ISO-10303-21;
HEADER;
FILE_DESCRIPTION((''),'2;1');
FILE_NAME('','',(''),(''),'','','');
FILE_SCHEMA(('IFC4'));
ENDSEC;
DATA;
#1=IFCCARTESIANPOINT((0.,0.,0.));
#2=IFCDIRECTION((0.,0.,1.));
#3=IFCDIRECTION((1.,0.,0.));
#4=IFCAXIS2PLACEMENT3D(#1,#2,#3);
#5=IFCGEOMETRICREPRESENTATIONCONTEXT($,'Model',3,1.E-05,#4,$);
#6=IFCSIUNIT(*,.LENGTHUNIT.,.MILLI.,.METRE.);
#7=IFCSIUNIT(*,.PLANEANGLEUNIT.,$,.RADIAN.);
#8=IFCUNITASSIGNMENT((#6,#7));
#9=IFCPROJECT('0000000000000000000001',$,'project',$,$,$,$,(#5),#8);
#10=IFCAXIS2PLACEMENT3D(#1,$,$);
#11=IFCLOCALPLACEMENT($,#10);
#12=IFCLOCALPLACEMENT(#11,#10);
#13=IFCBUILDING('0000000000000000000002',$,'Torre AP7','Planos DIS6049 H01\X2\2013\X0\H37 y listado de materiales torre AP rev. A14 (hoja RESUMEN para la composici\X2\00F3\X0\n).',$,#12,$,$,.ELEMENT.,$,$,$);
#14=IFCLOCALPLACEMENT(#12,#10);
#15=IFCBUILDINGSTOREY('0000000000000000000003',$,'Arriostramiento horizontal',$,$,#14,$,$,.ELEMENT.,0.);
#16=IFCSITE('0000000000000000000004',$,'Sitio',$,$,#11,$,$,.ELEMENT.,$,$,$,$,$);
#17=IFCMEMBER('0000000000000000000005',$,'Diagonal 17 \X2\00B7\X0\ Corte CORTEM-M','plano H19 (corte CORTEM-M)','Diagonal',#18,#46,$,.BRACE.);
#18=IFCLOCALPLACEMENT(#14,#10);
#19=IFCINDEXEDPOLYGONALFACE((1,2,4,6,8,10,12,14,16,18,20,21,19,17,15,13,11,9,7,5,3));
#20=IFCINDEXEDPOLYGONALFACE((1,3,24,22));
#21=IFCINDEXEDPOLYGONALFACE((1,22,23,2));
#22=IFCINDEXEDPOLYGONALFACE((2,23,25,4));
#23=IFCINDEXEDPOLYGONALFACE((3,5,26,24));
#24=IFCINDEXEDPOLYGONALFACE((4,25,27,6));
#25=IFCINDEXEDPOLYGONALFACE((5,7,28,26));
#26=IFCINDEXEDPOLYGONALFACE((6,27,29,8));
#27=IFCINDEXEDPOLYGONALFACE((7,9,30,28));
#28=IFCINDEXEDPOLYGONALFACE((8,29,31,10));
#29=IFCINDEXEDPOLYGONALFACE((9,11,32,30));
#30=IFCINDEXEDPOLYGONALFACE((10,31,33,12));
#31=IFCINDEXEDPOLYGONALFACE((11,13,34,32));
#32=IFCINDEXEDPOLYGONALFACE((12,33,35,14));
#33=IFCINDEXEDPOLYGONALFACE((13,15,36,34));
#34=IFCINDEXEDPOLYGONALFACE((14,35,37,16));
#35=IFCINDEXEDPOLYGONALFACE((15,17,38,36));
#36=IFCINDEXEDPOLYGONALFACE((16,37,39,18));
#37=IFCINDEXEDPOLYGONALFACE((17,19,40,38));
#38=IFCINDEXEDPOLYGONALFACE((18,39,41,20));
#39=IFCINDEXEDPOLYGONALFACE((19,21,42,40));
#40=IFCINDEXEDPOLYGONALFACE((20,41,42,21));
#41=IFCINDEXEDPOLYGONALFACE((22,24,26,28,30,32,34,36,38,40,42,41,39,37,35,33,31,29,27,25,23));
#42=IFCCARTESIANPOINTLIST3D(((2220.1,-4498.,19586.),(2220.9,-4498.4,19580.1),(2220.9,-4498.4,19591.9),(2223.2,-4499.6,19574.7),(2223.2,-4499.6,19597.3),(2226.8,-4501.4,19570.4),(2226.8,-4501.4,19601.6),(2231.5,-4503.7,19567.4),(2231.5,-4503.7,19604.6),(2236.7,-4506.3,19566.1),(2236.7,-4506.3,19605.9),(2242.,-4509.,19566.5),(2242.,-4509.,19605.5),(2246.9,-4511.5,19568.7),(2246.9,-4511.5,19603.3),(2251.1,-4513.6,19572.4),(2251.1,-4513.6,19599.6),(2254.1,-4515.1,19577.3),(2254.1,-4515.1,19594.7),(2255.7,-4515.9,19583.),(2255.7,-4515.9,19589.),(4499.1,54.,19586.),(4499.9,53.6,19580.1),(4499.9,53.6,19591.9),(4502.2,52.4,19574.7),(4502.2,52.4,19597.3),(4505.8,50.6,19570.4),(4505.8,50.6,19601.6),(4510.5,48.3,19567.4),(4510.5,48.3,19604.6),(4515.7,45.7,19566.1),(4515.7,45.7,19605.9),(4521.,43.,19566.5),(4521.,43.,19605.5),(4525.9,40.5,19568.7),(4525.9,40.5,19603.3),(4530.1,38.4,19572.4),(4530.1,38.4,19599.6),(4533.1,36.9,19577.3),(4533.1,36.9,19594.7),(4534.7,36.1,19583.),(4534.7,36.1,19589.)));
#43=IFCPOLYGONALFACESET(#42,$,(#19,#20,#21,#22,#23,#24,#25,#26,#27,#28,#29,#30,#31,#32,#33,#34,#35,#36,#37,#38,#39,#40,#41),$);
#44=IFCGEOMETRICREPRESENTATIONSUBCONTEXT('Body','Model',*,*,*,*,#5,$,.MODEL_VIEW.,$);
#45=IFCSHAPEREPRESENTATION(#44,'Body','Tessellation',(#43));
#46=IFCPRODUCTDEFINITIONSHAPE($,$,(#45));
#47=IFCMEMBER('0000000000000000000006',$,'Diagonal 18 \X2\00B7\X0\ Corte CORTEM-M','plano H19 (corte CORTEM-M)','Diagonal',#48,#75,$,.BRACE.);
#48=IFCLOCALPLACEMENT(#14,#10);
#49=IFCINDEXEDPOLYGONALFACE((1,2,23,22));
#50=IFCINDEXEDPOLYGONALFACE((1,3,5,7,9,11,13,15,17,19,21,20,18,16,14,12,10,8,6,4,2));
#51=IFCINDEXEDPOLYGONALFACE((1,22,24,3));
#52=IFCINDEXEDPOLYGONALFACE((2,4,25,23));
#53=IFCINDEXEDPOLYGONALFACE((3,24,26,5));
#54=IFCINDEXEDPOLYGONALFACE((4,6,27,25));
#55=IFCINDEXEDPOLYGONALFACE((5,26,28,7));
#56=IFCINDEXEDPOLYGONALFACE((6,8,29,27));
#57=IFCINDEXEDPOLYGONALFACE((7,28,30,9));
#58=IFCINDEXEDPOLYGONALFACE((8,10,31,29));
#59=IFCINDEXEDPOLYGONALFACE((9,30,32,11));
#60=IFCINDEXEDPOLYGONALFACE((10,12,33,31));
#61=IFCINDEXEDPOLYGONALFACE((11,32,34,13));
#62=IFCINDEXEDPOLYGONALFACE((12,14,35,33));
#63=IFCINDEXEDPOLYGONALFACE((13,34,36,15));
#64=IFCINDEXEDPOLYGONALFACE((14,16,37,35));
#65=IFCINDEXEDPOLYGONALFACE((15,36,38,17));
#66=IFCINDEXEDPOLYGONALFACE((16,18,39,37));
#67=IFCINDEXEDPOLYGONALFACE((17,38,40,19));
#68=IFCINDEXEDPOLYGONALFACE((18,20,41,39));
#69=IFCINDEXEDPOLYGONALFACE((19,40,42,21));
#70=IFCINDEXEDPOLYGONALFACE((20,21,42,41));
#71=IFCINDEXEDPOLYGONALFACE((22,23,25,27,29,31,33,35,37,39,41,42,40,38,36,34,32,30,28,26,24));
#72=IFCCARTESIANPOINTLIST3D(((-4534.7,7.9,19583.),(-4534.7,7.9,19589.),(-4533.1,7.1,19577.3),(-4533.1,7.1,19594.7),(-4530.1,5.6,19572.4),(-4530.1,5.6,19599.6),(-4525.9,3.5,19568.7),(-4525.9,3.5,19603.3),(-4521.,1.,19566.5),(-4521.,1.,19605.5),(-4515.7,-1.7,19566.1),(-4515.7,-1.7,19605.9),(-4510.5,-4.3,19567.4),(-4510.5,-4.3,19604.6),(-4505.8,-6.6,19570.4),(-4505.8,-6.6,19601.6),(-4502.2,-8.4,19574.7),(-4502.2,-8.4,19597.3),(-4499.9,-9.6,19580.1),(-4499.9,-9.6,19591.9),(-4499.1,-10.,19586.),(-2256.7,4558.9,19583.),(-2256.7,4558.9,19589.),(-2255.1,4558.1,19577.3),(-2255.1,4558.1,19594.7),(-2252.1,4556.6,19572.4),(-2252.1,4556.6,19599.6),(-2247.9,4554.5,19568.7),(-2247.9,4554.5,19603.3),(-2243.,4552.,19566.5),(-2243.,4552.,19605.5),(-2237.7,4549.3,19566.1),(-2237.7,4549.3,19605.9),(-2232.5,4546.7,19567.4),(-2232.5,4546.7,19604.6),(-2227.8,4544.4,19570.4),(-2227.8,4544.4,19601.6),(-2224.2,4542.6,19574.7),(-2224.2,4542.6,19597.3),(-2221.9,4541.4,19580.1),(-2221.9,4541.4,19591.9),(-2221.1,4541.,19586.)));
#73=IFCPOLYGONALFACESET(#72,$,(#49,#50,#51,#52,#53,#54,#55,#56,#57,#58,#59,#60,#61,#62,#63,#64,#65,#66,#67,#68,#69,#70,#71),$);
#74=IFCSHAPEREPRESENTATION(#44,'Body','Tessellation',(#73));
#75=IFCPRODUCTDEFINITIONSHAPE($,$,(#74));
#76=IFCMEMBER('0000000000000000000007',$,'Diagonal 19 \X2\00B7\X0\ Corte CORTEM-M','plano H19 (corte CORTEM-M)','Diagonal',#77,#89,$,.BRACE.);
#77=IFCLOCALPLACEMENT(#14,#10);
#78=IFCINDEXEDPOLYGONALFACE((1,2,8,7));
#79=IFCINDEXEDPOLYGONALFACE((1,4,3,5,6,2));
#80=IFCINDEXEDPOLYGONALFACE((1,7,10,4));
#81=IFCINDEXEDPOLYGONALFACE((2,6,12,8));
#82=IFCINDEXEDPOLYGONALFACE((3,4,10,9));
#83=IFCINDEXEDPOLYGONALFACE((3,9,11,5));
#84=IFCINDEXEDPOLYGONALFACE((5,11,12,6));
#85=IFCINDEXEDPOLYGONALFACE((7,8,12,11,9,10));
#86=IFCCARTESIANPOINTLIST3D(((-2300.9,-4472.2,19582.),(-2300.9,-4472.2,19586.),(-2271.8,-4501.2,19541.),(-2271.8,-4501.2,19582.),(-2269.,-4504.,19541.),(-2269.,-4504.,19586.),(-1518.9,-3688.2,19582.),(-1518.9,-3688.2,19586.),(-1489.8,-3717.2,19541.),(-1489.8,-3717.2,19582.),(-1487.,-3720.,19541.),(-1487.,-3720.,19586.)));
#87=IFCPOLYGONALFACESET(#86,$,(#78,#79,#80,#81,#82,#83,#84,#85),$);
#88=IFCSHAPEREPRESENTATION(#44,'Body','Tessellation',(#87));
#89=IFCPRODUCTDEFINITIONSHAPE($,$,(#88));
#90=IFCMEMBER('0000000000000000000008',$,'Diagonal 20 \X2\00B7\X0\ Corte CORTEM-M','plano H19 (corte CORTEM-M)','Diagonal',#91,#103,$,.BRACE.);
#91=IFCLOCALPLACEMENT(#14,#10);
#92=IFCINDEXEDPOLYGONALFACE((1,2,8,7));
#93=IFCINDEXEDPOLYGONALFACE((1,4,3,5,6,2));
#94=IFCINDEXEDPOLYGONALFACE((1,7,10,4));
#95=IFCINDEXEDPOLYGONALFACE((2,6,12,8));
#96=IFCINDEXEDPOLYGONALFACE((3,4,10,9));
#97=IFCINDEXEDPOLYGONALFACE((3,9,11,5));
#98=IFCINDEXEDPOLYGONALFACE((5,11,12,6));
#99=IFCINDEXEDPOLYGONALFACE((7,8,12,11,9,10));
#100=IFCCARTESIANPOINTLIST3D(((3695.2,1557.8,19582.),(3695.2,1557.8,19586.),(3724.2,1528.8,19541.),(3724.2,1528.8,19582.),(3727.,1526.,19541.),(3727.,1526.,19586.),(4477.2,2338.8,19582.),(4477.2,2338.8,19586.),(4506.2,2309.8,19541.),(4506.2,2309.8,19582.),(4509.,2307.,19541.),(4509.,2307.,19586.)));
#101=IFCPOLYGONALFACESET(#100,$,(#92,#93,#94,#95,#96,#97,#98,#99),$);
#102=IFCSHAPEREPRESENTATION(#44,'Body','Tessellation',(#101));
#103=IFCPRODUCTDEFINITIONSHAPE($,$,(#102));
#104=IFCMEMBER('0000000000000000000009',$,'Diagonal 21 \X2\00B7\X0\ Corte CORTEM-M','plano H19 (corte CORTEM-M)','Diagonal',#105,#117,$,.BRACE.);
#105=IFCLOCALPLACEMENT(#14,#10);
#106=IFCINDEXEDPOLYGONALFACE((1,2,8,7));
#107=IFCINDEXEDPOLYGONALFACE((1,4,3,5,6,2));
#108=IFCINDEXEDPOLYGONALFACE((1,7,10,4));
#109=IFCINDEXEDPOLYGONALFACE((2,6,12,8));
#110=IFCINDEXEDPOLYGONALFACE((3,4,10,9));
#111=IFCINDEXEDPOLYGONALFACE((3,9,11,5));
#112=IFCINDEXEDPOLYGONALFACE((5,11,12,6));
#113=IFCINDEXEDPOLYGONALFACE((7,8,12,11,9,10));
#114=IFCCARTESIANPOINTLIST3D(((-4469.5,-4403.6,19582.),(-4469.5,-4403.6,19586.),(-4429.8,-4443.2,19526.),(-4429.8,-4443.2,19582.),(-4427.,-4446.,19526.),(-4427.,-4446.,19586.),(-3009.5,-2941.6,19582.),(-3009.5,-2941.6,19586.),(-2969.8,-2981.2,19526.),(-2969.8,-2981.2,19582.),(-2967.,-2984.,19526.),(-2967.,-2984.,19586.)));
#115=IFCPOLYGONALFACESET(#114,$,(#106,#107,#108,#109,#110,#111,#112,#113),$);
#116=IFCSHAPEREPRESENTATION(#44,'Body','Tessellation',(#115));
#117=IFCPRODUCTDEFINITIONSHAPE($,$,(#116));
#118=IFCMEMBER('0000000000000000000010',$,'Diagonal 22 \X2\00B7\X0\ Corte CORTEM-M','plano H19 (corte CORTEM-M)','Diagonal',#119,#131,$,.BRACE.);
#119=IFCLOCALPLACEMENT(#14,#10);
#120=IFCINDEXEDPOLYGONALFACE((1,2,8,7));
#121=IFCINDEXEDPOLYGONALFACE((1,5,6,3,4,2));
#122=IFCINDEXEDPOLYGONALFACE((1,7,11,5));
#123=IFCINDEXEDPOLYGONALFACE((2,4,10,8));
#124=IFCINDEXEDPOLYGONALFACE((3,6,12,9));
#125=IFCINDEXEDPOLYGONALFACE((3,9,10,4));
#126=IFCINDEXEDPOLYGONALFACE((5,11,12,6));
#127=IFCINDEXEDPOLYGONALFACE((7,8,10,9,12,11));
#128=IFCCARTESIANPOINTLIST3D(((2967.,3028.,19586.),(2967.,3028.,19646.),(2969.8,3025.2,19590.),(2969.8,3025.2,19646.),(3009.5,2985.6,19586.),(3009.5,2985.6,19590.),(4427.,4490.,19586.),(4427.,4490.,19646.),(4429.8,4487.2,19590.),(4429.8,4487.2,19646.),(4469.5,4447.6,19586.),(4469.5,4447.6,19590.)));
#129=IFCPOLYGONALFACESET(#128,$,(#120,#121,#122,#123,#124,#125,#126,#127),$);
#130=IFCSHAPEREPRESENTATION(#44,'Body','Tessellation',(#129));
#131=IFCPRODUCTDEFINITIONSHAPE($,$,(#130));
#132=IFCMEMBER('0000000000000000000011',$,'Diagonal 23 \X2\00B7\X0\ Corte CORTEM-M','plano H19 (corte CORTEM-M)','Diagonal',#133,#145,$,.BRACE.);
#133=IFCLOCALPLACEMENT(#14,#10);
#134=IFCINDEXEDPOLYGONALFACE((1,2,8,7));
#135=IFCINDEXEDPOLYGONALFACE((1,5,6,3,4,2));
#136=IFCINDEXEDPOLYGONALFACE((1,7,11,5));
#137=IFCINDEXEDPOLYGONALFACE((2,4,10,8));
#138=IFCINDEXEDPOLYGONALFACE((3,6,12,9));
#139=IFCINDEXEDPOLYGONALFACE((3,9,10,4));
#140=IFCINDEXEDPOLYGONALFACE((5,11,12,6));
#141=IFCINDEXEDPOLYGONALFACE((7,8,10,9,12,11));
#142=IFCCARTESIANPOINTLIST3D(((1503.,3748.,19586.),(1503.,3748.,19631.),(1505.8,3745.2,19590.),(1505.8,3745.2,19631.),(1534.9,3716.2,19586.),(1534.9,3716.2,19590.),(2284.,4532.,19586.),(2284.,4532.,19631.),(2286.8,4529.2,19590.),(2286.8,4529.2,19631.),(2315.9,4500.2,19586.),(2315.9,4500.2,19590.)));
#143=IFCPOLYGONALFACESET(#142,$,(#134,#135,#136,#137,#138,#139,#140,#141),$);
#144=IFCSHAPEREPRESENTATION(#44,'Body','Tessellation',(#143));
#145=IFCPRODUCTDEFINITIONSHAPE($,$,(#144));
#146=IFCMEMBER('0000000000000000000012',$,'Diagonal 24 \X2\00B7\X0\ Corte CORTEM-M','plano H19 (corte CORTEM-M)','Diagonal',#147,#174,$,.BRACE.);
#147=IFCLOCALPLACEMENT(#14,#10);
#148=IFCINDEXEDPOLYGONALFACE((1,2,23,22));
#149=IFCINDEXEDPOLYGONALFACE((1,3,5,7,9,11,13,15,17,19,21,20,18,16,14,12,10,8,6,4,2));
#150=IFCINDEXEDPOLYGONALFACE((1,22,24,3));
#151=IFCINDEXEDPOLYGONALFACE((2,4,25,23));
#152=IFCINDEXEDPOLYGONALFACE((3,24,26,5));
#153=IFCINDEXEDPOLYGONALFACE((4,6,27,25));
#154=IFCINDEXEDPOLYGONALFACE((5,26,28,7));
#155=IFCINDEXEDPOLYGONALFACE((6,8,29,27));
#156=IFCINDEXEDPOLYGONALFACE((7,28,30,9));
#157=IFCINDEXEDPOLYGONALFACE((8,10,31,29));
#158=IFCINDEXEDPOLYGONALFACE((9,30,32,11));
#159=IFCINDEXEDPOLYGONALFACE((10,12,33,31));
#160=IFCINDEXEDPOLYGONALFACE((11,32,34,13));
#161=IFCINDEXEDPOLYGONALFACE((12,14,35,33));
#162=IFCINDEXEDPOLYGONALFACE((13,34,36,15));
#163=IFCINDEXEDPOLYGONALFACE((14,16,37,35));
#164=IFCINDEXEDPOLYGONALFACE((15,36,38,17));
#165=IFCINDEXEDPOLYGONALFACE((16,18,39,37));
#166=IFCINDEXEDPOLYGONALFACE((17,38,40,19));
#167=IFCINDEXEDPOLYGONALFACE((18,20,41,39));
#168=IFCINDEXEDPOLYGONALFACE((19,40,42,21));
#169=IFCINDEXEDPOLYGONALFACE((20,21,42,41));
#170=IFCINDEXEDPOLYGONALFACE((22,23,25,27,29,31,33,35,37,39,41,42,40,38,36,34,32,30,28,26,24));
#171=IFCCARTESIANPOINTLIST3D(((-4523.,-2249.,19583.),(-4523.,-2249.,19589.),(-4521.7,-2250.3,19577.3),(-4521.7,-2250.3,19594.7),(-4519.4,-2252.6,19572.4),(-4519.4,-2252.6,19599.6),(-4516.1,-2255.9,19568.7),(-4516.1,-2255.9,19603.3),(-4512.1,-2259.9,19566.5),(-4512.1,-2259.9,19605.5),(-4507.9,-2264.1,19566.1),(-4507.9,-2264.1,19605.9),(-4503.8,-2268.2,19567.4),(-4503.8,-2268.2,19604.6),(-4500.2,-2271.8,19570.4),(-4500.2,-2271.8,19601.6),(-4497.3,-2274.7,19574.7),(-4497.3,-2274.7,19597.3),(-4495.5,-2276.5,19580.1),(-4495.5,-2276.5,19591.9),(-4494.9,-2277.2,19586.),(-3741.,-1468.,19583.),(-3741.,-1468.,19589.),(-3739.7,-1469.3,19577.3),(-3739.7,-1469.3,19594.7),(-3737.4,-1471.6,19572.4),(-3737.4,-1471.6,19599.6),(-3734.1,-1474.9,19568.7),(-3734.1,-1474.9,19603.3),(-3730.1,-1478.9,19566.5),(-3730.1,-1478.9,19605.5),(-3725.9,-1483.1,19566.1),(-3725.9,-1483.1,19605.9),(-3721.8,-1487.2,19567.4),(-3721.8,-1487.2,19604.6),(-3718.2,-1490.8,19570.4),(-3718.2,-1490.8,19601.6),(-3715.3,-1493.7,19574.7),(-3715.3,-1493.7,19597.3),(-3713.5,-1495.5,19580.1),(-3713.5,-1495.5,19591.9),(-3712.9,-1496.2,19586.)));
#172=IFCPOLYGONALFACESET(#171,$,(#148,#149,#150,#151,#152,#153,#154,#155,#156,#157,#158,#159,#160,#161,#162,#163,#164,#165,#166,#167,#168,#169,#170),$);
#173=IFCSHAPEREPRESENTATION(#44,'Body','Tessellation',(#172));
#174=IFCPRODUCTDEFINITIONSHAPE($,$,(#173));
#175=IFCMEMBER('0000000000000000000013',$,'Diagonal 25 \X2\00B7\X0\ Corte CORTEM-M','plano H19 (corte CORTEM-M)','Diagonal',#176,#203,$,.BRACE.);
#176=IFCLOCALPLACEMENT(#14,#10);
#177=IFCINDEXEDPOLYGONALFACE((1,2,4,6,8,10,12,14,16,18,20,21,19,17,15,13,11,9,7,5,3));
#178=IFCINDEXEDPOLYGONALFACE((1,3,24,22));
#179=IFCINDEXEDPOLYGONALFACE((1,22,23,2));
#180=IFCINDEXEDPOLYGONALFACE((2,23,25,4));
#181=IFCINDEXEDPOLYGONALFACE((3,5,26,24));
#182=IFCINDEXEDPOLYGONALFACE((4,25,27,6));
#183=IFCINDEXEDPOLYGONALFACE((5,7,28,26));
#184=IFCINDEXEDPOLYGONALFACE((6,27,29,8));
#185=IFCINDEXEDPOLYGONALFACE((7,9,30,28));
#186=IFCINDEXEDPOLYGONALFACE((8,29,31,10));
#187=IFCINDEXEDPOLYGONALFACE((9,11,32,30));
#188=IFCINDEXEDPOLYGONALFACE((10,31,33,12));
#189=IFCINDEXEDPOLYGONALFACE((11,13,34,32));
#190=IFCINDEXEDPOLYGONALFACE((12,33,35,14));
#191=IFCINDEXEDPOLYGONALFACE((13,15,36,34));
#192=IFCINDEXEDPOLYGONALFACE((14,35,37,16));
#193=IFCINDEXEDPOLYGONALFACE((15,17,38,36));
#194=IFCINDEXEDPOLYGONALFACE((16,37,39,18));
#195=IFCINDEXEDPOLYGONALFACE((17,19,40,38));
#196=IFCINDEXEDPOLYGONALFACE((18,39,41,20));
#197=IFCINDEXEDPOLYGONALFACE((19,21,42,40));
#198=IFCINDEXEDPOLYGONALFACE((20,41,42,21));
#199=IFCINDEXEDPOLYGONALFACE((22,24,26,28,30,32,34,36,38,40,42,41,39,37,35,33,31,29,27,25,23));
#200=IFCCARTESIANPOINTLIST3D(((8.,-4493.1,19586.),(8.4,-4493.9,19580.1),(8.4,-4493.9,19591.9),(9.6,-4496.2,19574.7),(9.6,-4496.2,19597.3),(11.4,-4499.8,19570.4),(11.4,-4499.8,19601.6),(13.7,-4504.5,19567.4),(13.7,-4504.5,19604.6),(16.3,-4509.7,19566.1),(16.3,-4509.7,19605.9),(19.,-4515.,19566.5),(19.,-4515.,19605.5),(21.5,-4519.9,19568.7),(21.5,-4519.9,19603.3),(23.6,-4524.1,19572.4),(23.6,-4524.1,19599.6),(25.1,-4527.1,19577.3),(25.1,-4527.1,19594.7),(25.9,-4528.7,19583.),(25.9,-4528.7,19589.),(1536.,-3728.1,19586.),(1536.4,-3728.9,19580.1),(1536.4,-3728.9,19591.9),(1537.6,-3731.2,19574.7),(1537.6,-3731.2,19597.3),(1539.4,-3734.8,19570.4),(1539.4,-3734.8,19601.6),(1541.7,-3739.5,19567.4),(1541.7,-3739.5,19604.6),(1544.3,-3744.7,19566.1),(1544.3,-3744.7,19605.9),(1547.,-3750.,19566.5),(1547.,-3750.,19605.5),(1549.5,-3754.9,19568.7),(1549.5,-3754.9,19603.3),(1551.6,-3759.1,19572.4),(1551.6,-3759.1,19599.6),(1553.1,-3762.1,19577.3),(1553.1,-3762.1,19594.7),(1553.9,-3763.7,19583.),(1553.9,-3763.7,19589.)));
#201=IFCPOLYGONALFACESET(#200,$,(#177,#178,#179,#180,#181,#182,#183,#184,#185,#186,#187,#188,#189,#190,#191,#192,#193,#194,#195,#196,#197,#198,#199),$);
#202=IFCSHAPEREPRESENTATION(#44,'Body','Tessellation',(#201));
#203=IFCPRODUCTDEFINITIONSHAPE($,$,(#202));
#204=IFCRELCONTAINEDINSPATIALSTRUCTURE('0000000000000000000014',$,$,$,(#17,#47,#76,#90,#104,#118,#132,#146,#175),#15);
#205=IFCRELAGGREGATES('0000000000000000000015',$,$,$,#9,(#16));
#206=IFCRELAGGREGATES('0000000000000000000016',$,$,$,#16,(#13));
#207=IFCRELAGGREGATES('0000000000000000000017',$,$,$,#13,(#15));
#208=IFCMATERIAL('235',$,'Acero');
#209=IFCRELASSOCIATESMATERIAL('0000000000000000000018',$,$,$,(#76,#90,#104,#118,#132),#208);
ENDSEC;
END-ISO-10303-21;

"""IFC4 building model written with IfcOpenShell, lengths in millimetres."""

from ifc_helpers import new_model, si_unit, frame, frame_2d, origin, origin_with_axes, place, context, subcontext, project, spatial, circle, l_section, extrude, material, element, save


model = new_model("IFC4")

# Units and contexts
model_context = context("Model", 3, precision=1e-05, world=origin_with_axes())
body_context = subcontext(model_context, "Body", "Model", "MODEL_VIEW")
ifc_project = project(units=[si_unit("LENGTHUNIT", "METRE", prefix="MILLI"), si_unit("PLANEANGLEUNIT", "RADIAN")], contexts=[model_context])

# Site, building, storey
site_placement = place(None, origin())
site = spatial("IfcSite", under=ifc_project, at=site_placement, Name="Sitio", CompositionType="ELEMENT")
building_placement = place(site_placement, origin())
building = spatial("IfcBuilding", under=site, at=building_placement, Name="Torre AP7", Description="Planos DIS6049 H01–H37 y listado de materiales torre AP rev. A14 (hoja RESUMEN para la composición).", CompositionType="ELEMENT")
storey_placement = place(building_placement, origin())
storey = spatial("IfcBuildingStorey", under=building, at=storey_placement, Name="Arriostramiento horizontal", CompositionType="ELEMENT", Elevation=0.0)

# Members
ifc_material = material(Name="235", Category="Acero")
member_1_placement = place(storey_placement, frame((4517.0, 45.0, 19586.0), z_axis=(-0.447685, -0.894191, 0.0), x_axis=(-0.894191, 0.447685, 0.0)))
element("IfcMember", 1, at=member_1_placement, inside=storey, Name="Diagonal 17 · Corte CORTEM-M", Description="plano H19 (corte CORTEM-M)", ObjectType="Diagonal", PredefinedType="BRACE", context=body_context, shape_type="SweptSolid", body=[
    extrude(circle(Radius=20.0), None, (0.0, 0.0, 1.0), 5090.6),
])
member_2_placement = place(storey_placement, frame((-2239.0, 4550.0, 19586.0), z_axis=(-0.447607, -0.894231, 0.0), x_axis=(0.894231, -0.447607, 0.0)))
element("IfcMember", 2, at=member_2_placement, inside=storey, Name="Diagonal 18 · Corte CORTEM-M", Description="plano H19 (corte CORTEM-M)", ObjectType="Diagonal", PredefinedType="BRACE", context=body_context, shape_type="SweptSolid", body=[
    extrude(circle(Radius=20.0), None, (0.0, 0.0, 1.0), 5089.3),
])
member_3_placement = place(storey_placement, frame((-1487.0, -3720.0, 19586.0), z_axis=(-0.706203, -0.708009, 0.0), x_axis=(-0.708009, 0.706203, 0.0)))
element("IfcMember", 3, at=member_3_placement, inside=storey, material=ifc_material, Name="Diagonal 19 · Corte CORTEM-M", Description="plano H19 (corte CORTEM-M)", ObjectType="Diagonal", PredefinedType="BRACE", context=body_context, shape_type="SweptSolid", body=[
    extrude(l_section(Depth=45.0, Width=45.0, Thickness=4.0, at=frame_2d((22.5, 22.5))), None, (0.0, 0.0, 1.0), 1107.3),
])
member_4_placement = place(storey_placement, frame((4509.0, 2307.0, 19586.0), z_axis=(-0.707559, -0.706654, 0.0), x_axis=(-0.706654, 0.707559, 0.0)))
element("IfcMember", 4, at=member_4_placement, inside=storey, material=ifc_material, Name="Diagonal 20 · Corte CORTEM-M", Description="plano H19 (corte CORTEM-M)", ObjectType="Diagonal", PredefinedType="BRACE", context=body_context, shape_type="SweptSolid", body=[
    extrude(l_section(Depth=45.0, Width=45.0, Thickness=4.0, at=frame_2d((22.5, 22.5))), None, (0.0, 0.0, 1.0), 1105.2),
])
for number, where, z_axis, x_axis, name in (
    (5, (-2967.0, -2984.0, 19586.0), (-0.706623, -0.707591, 0.0), (-0.707591, 0.706623, 0.0), "Diagonal 21 · Corte CORTEM-M"),
    (6, (4427.0, 4490.0, 19586.0), (-0.706623, -0.707591, 0.0), (0.707591, -0.706623, 0.0), "Diagonal 22 · Corte CORTEM-M"),
):
    element("IfcMember", number, at=place(storey_placement, frame(where, z_axis=z_axis, x_axis=x_axis)), inside=storey, material=ifc_material, Name=name, Description="plano H19 (corte CORTEM-M)", ObjectType="Diagonal", PredefinedType="BRACE", context=body_context, shape_type="SweptSolid", body=[
        extrude(l_section(Depth=60.0, Width=60.0, Thickness=4.0, at=frame_2d((30.0, 30.0))), None, (0.0, 0.0, 1.0), 2066.2),
    ])
member_5_placement = place(storey_placement, frame((2284.0, 4532.0, 19586.0), z_axis=(-0.70575, -0.708461, 0.0), x_axis=(0.708461, -0.70575, 0.0)))
element("IfcMember", 7, at=member_5_placement, inside=storey, material=ifc_material, Name="Diagonal 23 · Corte CORTEM-M", Description="plano H19 (corte CORTEM-M)", ObjectType="Diagonal", PredefinedType="BRACE", context=body_context, shape_type="SweptSolid", body=[
    extrude(l_section(Depth=45.0, Width=45.0, Thickness=4.0, at=frame_2d((22.5, 22.5))), None, (0.0, 0.0, 1.0), 1106.6),
])
member_6_placement = place(storey_placement, frame((-3727.0, -1482.0, 19586.0), z_axis=(-0.707559, -0.706654, 0.0), x_axis=(0.706654, -0.707559, 0.0)))
element("IfcMember", 8, at=member_6_placement, inside=storey, Name="Diagonal 24 · Corte CORTEM-M", Description="plano H19 (corte CORTEM-M)", ObjectType="Diagonal", PredefinedType="BRACE", context=body_context, shape_type="SweptSolid", body=[
    extrude(circle(Radius=20.0), None, (0.0, 0.0, 1.0), 1105.2),
])
member_7_placement = place(storey_placement, frame((1545.0, -3746.0, 19586.0), z_axis=(-0.894193, -0.447682, 0.0), x_axis=(-0.447682, 0.894193, 0.0)))
element("IfcMember", 9, at=member_7_placement, inside=storey, Name="Diagonal 25 · Corte CORTEM-M", Description="plano H19 (corte CORTEM-M)", ObjectType="Diagonal", PredefinedType="BRACE", context=body_context, shape_type="SweptSolid", body=[
    extrude(circle(Radius=20.0), None, (0.0, 0.0, 1.0), 1708.8),
])

save(model, "model.ifc")
